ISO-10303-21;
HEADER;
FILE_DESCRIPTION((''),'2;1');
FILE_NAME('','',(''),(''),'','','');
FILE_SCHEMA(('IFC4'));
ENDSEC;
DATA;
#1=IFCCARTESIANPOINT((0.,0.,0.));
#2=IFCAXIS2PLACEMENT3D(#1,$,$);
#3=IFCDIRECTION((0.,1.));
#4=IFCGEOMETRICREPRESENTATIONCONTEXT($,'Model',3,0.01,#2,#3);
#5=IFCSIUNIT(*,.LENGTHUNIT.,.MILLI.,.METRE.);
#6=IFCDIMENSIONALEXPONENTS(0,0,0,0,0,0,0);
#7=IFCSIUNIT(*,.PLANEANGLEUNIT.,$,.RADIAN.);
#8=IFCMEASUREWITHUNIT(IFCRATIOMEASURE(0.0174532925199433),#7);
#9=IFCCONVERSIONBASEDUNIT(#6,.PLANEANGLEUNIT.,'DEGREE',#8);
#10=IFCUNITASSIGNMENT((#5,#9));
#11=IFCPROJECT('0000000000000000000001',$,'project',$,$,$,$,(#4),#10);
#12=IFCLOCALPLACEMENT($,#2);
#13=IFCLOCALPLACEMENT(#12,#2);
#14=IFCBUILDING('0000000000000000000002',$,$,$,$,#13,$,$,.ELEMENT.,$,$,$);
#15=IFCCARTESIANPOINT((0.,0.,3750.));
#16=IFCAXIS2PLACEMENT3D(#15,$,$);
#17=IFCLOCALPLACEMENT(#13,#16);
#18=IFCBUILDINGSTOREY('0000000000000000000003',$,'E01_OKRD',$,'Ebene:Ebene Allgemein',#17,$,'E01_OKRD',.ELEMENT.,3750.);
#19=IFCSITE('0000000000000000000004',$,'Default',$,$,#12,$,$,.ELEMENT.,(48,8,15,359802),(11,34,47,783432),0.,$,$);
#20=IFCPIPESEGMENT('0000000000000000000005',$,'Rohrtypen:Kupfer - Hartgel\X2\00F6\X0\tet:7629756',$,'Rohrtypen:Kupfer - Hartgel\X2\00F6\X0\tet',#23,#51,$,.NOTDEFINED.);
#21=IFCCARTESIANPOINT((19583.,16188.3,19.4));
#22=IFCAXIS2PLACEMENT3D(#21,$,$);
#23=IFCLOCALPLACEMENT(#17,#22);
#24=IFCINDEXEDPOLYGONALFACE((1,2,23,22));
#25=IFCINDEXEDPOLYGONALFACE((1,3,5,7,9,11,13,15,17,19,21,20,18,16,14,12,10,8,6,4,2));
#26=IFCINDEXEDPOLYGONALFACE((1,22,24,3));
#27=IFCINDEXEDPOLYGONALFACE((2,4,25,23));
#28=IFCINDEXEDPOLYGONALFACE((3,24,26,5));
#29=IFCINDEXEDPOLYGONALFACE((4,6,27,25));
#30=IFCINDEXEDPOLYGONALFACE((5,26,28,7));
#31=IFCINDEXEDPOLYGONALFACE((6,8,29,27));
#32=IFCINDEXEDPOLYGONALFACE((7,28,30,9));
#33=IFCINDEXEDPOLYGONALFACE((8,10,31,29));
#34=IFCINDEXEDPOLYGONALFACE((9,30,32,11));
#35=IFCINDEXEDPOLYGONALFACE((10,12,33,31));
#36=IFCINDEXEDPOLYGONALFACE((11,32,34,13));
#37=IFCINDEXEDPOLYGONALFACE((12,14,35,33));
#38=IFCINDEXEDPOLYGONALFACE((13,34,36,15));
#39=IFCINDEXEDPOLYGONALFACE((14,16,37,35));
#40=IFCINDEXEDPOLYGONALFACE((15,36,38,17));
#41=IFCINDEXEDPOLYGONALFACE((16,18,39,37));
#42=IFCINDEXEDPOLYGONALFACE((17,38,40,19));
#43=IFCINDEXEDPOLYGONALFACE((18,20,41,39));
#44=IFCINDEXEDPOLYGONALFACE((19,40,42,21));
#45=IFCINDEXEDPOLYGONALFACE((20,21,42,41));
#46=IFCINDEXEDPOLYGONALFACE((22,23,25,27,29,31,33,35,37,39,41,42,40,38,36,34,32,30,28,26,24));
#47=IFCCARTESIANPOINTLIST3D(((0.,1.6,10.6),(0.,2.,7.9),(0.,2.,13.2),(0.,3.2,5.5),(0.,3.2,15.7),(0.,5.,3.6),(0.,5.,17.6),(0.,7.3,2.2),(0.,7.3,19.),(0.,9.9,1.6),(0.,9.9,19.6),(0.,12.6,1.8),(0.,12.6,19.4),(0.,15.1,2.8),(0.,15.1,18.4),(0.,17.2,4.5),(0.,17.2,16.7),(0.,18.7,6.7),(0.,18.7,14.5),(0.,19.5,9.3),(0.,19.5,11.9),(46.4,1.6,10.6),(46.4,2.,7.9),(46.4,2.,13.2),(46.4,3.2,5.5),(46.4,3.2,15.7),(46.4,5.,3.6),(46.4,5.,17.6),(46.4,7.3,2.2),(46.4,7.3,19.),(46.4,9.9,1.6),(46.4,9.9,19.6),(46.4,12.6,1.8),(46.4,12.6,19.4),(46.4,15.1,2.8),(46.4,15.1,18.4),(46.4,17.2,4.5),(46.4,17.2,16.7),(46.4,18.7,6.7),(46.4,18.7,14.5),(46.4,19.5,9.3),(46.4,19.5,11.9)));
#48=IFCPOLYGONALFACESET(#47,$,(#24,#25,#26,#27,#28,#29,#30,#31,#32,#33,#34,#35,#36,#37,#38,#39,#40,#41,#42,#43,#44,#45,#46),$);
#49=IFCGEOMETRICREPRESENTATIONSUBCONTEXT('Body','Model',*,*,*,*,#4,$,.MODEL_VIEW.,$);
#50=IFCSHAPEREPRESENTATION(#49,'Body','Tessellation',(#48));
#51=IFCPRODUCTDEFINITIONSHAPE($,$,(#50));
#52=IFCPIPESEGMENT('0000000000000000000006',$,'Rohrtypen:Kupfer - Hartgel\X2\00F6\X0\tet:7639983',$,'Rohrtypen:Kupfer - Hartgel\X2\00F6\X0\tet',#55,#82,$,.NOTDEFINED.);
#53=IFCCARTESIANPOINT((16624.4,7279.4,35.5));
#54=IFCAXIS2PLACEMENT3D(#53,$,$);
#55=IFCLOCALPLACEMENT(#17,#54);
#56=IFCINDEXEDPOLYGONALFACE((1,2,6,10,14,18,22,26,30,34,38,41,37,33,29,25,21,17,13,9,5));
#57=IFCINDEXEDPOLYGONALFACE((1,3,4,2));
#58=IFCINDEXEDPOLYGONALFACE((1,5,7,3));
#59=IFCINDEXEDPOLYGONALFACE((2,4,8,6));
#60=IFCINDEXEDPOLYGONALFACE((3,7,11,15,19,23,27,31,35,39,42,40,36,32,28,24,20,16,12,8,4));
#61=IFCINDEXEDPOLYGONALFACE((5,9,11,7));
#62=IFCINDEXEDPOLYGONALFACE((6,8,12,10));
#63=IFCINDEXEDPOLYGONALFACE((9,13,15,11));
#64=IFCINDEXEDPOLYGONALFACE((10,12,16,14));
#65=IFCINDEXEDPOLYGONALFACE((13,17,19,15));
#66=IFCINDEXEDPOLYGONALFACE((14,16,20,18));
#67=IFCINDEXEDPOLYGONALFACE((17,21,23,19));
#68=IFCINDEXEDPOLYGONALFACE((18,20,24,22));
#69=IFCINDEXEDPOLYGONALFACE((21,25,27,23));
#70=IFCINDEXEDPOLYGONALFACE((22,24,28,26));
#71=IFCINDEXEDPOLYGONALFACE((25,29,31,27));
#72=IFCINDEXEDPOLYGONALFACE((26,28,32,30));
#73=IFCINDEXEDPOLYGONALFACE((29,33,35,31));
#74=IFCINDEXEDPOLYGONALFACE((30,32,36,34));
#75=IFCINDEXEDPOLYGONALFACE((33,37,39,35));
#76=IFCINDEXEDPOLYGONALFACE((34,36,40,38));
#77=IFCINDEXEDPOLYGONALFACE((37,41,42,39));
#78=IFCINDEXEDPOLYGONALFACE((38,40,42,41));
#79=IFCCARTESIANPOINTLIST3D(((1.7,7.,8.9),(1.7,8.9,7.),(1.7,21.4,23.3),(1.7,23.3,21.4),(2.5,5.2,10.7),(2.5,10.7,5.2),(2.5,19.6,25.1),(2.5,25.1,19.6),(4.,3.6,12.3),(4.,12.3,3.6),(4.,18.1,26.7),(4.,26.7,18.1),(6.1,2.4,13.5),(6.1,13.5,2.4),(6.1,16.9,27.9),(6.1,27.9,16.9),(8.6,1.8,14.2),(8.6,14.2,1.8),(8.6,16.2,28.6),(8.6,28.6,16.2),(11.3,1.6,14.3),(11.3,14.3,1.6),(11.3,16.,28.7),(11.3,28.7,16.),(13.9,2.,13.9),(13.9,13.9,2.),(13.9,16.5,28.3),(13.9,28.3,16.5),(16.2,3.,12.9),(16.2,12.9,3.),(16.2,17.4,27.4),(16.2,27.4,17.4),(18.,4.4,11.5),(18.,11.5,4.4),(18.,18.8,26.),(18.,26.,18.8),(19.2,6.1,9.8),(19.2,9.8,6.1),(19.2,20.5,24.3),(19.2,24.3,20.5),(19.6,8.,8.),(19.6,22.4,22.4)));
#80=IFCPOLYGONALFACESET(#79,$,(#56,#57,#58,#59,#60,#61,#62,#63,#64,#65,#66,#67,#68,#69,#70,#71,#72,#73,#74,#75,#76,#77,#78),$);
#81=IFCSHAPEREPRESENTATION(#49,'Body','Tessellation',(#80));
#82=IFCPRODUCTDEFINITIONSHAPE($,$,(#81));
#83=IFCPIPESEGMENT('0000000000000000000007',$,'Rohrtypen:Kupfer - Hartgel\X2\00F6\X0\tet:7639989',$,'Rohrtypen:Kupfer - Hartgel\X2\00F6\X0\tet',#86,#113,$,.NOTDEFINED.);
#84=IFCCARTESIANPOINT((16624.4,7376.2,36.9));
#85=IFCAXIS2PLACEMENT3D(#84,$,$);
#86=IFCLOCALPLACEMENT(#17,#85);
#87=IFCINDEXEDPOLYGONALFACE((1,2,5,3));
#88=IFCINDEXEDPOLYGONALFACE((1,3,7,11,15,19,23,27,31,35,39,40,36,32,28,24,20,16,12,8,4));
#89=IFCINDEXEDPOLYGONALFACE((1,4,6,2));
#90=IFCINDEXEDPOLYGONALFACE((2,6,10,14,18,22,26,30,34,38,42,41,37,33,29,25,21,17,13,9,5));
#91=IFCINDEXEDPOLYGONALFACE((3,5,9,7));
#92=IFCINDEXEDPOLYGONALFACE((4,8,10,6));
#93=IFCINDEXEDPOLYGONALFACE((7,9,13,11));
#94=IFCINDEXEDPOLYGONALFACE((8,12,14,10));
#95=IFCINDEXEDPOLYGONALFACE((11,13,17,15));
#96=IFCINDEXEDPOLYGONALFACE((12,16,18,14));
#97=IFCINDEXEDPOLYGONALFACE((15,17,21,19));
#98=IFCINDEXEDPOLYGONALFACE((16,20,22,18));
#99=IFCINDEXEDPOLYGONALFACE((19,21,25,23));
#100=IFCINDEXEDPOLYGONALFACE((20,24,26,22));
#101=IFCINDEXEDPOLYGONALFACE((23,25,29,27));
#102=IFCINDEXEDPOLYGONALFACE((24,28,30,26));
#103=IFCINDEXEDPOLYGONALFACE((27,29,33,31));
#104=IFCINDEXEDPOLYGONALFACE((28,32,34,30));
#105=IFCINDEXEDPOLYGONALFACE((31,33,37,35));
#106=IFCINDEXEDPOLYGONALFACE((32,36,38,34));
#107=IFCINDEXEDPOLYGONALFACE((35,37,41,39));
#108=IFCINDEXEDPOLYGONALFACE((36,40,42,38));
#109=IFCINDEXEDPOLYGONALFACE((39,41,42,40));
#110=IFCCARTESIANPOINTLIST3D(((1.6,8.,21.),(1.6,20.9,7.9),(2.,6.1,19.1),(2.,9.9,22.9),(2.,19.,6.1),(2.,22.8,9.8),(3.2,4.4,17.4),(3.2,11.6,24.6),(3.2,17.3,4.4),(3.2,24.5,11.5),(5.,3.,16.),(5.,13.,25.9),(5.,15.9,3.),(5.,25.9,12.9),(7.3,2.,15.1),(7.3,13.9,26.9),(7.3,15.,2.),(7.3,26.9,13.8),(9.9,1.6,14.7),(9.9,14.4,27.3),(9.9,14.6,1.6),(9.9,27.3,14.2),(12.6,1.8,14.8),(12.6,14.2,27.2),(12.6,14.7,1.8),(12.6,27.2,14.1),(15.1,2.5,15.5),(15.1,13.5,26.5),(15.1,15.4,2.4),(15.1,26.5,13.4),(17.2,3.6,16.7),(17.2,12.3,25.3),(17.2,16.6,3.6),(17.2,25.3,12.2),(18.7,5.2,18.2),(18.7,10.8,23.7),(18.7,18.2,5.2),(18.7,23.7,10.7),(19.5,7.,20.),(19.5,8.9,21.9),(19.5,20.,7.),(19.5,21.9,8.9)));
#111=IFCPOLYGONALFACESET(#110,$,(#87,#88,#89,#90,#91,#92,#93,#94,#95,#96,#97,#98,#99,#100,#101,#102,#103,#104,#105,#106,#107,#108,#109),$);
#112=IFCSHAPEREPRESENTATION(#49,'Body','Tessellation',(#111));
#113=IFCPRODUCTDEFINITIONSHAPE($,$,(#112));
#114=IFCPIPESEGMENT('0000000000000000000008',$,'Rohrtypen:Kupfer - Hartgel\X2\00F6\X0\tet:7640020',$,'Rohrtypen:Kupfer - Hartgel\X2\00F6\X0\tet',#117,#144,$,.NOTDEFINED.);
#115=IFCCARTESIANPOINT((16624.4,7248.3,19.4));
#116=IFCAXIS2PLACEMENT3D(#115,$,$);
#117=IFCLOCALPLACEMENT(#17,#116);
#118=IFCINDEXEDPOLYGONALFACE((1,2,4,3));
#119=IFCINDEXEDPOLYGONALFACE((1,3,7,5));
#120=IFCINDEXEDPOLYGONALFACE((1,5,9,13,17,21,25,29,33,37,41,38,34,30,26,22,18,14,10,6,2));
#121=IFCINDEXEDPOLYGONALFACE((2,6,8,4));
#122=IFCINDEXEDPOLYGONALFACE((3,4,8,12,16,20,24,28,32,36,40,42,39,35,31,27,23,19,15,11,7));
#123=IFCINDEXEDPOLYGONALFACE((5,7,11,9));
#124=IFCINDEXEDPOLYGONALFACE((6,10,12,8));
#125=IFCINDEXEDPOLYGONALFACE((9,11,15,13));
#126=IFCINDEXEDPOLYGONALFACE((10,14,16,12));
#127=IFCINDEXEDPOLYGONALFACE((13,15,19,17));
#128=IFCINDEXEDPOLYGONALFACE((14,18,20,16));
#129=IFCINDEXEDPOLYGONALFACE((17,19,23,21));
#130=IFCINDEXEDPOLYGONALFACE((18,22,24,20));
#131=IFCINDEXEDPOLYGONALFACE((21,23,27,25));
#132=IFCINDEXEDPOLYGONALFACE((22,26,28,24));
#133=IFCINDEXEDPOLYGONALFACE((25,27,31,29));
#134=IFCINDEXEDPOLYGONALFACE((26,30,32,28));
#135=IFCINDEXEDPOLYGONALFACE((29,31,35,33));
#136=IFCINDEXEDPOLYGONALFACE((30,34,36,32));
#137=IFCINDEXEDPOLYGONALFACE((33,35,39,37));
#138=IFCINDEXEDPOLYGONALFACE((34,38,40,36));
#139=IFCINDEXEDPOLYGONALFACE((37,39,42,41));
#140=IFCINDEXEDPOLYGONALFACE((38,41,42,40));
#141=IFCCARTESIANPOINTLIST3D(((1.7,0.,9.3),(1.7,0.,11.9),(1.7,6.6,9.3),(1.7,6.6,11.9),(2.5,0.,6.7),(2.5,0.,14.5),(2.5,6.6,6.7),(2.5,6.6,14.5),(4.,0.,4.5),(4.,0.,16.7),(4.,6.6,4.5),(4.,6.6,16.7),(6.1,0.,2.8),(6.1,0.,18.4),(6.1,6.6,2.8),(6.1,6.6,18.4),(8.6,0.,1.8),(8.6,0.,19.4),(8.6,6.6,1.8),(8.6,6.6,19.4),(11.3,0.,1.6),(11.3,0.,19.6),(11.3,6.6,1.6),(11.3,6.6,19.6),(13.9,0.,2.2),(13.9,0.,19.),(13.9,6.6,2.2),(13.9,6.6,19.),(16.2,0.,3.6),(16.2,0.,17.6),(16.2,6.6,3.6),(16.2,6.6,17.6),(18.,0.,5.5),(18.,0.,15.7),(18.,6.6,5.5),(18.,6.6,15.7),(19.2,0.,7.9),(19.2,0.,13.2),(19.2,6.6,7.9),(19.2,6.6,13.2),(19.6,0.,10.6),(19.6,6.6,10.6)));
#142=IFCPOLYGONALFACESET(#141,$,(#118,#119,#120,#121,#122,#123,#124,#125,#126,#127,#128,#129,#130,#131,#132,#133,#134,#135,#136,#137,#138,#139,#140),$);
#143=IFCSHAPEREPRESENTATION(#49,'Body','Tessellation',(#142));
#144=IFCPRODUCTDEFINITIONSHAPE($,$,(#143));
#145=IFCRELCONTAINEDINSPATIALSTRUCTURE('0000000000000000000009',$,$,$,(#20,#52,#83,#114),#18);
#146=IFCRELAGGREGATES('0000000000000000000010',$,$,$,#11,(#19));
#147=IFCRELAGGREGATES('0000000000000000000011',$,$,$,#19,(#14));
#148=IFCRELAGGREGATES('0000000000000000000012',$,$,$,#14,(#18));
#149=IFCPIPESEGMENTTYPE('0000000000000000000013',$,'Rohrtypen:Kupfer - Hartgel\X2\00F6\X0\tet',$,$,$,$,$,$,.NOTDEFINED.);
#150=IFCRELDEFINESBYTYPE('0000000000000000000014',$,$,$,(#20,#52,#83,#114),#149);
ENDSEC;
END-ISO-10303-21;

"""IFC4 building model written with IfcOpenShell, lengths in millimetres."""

from ifc_helpers import new_model, entity, si_unit, converted_unit, direction, frame, frame_2d, origin, origin_2d_with_axis, place, context, subcontext, project, spatial, circle, extrude, type_object, element, save


model = new_model("IFC4")

# Units and contexts
model_context = context("Model", 3, precision=0.01, world=origin(), true_north=direction((0.0, 1.0)))
body_context = subcontext(model_context, "Body", "Model", "MODEL_VIEW")
ifc_project = project(units=[si_unit("LENGTHUNIT", "METRE", prefix="MILLI"), converted_unit("PLANEANGLEUNIT", "DEGREE", entity("IfcRatioMeasure", 0.0174532925199433), si_unit("PLANEANGLEUNIT", "RADIAN"), dimensions=[0, 0, 0, 0, 0, 0, 0])], contexts=[model_context])

# Site, building, storey
site_placement = place(None, origin())
site = spatial("IfcSite", under=ifc_project, at=site_placement, Name="Default", CompositionType="ELEMENT", RefLatitude=(48, 8, 15, 359802), RefLongitude=(11, 34, 47, 783432), RefElevation=0.0)
building_placement = place(site_placement, origin())
building = spatial("IfcBuilding", under=site, at=building_placement, CompositionType="ELEMENT")
storey_placement = place(building_placement, frame((0.0, 0.0, 3750.0)))
storey = spatial("IfcBuildingStorey", under=building, at=storey_placement, Name="E01_OKRD", ObjectType="Ebene:Ebene Allgemein", LongName="E01_OKRD", CompositionType="ELEMENT", Elevation=3750.0)

# Pipe segments
pipe_segment_type = type_object("IfcPipeSegmentType", Name="Rohrtypen:Kupfer - Hartgelötet", PredefinedType="NOTDEFINED")
pipe_segment_1_placement = place(storey_placement, frame((19583.0, 16188.3, 19.4)))
element("IfcPipeSegment", 1, at=pipe_segment_1_placement, inside=storey, type_object=pipe_segment_type, Name="Rohrtypen:Kupfer - Hartgelötet:7629756", ObjectType="Rohrtypen:Kupfer - Hartgelötet", PredefinedType="NOTDEFINED", context=body_context, shape_type="SweptSolid", body=[
    extrude(circle(Radius=9.0, at=origin_2d_with_axis()), frame((0.0, 10.6, 10.6), z_axis=(1.0, 0.0, 0.0), x_axis=(0.0, -1.0, 0.0)), (0.0, 0.0, 1.0), 46.4),
])
pipe_segment_2_placement = place(storey_placement, frame((16624.4, 7279.4, 35.5)))
element("IfcPipeSegment", 2, at=pipe_segment_2_placement, inside=storey, type_object=pipe_segment_type, Name="Rohrtypen:Kupfer - Hartgelötet:7639983", ObjectType="Rohrtypen:Kupfer - Hartgelötet", PredefinedType="NOTDEFINED", context=body_context, shape_type="SweptSolid", body=[
    extrude(circle(Radius=9.0, at=frame_2d((0.0, 0.0), x_axis=(1.0, 0.0))), frame((10.6, 8.0, 8.0), z_axis=(0.0, 0.707107, 0.707107), x_axis=(1.0, 0.0, 0.0)), (0.0, 0.0, 1.0), 20.4),
])
pipe_segment_3_placement = place(storey_placement, frame((16624.4, 7376.2, 36.9)))
element("IfcPipeSegment", 3, at=pipe_segment_3_placement, inside=storey, type_object=pipe_segment_type, Name="Rohrtypen:Kupfer - Hartgelötet:7639989", ObjectType="Rohrtypen:Kupfer - Hartgelötet", PredefinedType="NOTDEFINED", context=body_context, shape_type="SweptSolid", body=[
    extrude(circle(Radius=9.0, at=origin_2d_with_axis()), frame((10.6, 20.9, 7.9), z_axis=(0.0, -0.70394, 0.71026), x_axis=(-1.0, 0.0, 0.0)), (0.0, 0.0, 1.0), 18.4),
])
pipe_segment_4_placement = place(storey_placement, frame((16624.4, 7248.3, 19.4)))
element("IfcPipeSegment", 4, at=pipe_segment_4_placement, inside=storey, type_object=pipe_segment_type, Name="Rohrtypen:Kupfer - Hartgelötet:7640020", ObjectType="Rohrtypen:Kupfer - Hartgelötet", PredefinedType="NOTDEFINED", context=body_context, shape_type="SweptSolid", body=[
    extrude(circle(Radius=9.0, at=origin_2d_with_axis()), frame((10.6, 0.0, 10.6), z_axis=(0.0, 1.0, 0.0), x_axis=(1.0, 0.0, 0.0)), (0.0, 0.0, 1.0), 6.6),
])

save(model, "model.ifc")
